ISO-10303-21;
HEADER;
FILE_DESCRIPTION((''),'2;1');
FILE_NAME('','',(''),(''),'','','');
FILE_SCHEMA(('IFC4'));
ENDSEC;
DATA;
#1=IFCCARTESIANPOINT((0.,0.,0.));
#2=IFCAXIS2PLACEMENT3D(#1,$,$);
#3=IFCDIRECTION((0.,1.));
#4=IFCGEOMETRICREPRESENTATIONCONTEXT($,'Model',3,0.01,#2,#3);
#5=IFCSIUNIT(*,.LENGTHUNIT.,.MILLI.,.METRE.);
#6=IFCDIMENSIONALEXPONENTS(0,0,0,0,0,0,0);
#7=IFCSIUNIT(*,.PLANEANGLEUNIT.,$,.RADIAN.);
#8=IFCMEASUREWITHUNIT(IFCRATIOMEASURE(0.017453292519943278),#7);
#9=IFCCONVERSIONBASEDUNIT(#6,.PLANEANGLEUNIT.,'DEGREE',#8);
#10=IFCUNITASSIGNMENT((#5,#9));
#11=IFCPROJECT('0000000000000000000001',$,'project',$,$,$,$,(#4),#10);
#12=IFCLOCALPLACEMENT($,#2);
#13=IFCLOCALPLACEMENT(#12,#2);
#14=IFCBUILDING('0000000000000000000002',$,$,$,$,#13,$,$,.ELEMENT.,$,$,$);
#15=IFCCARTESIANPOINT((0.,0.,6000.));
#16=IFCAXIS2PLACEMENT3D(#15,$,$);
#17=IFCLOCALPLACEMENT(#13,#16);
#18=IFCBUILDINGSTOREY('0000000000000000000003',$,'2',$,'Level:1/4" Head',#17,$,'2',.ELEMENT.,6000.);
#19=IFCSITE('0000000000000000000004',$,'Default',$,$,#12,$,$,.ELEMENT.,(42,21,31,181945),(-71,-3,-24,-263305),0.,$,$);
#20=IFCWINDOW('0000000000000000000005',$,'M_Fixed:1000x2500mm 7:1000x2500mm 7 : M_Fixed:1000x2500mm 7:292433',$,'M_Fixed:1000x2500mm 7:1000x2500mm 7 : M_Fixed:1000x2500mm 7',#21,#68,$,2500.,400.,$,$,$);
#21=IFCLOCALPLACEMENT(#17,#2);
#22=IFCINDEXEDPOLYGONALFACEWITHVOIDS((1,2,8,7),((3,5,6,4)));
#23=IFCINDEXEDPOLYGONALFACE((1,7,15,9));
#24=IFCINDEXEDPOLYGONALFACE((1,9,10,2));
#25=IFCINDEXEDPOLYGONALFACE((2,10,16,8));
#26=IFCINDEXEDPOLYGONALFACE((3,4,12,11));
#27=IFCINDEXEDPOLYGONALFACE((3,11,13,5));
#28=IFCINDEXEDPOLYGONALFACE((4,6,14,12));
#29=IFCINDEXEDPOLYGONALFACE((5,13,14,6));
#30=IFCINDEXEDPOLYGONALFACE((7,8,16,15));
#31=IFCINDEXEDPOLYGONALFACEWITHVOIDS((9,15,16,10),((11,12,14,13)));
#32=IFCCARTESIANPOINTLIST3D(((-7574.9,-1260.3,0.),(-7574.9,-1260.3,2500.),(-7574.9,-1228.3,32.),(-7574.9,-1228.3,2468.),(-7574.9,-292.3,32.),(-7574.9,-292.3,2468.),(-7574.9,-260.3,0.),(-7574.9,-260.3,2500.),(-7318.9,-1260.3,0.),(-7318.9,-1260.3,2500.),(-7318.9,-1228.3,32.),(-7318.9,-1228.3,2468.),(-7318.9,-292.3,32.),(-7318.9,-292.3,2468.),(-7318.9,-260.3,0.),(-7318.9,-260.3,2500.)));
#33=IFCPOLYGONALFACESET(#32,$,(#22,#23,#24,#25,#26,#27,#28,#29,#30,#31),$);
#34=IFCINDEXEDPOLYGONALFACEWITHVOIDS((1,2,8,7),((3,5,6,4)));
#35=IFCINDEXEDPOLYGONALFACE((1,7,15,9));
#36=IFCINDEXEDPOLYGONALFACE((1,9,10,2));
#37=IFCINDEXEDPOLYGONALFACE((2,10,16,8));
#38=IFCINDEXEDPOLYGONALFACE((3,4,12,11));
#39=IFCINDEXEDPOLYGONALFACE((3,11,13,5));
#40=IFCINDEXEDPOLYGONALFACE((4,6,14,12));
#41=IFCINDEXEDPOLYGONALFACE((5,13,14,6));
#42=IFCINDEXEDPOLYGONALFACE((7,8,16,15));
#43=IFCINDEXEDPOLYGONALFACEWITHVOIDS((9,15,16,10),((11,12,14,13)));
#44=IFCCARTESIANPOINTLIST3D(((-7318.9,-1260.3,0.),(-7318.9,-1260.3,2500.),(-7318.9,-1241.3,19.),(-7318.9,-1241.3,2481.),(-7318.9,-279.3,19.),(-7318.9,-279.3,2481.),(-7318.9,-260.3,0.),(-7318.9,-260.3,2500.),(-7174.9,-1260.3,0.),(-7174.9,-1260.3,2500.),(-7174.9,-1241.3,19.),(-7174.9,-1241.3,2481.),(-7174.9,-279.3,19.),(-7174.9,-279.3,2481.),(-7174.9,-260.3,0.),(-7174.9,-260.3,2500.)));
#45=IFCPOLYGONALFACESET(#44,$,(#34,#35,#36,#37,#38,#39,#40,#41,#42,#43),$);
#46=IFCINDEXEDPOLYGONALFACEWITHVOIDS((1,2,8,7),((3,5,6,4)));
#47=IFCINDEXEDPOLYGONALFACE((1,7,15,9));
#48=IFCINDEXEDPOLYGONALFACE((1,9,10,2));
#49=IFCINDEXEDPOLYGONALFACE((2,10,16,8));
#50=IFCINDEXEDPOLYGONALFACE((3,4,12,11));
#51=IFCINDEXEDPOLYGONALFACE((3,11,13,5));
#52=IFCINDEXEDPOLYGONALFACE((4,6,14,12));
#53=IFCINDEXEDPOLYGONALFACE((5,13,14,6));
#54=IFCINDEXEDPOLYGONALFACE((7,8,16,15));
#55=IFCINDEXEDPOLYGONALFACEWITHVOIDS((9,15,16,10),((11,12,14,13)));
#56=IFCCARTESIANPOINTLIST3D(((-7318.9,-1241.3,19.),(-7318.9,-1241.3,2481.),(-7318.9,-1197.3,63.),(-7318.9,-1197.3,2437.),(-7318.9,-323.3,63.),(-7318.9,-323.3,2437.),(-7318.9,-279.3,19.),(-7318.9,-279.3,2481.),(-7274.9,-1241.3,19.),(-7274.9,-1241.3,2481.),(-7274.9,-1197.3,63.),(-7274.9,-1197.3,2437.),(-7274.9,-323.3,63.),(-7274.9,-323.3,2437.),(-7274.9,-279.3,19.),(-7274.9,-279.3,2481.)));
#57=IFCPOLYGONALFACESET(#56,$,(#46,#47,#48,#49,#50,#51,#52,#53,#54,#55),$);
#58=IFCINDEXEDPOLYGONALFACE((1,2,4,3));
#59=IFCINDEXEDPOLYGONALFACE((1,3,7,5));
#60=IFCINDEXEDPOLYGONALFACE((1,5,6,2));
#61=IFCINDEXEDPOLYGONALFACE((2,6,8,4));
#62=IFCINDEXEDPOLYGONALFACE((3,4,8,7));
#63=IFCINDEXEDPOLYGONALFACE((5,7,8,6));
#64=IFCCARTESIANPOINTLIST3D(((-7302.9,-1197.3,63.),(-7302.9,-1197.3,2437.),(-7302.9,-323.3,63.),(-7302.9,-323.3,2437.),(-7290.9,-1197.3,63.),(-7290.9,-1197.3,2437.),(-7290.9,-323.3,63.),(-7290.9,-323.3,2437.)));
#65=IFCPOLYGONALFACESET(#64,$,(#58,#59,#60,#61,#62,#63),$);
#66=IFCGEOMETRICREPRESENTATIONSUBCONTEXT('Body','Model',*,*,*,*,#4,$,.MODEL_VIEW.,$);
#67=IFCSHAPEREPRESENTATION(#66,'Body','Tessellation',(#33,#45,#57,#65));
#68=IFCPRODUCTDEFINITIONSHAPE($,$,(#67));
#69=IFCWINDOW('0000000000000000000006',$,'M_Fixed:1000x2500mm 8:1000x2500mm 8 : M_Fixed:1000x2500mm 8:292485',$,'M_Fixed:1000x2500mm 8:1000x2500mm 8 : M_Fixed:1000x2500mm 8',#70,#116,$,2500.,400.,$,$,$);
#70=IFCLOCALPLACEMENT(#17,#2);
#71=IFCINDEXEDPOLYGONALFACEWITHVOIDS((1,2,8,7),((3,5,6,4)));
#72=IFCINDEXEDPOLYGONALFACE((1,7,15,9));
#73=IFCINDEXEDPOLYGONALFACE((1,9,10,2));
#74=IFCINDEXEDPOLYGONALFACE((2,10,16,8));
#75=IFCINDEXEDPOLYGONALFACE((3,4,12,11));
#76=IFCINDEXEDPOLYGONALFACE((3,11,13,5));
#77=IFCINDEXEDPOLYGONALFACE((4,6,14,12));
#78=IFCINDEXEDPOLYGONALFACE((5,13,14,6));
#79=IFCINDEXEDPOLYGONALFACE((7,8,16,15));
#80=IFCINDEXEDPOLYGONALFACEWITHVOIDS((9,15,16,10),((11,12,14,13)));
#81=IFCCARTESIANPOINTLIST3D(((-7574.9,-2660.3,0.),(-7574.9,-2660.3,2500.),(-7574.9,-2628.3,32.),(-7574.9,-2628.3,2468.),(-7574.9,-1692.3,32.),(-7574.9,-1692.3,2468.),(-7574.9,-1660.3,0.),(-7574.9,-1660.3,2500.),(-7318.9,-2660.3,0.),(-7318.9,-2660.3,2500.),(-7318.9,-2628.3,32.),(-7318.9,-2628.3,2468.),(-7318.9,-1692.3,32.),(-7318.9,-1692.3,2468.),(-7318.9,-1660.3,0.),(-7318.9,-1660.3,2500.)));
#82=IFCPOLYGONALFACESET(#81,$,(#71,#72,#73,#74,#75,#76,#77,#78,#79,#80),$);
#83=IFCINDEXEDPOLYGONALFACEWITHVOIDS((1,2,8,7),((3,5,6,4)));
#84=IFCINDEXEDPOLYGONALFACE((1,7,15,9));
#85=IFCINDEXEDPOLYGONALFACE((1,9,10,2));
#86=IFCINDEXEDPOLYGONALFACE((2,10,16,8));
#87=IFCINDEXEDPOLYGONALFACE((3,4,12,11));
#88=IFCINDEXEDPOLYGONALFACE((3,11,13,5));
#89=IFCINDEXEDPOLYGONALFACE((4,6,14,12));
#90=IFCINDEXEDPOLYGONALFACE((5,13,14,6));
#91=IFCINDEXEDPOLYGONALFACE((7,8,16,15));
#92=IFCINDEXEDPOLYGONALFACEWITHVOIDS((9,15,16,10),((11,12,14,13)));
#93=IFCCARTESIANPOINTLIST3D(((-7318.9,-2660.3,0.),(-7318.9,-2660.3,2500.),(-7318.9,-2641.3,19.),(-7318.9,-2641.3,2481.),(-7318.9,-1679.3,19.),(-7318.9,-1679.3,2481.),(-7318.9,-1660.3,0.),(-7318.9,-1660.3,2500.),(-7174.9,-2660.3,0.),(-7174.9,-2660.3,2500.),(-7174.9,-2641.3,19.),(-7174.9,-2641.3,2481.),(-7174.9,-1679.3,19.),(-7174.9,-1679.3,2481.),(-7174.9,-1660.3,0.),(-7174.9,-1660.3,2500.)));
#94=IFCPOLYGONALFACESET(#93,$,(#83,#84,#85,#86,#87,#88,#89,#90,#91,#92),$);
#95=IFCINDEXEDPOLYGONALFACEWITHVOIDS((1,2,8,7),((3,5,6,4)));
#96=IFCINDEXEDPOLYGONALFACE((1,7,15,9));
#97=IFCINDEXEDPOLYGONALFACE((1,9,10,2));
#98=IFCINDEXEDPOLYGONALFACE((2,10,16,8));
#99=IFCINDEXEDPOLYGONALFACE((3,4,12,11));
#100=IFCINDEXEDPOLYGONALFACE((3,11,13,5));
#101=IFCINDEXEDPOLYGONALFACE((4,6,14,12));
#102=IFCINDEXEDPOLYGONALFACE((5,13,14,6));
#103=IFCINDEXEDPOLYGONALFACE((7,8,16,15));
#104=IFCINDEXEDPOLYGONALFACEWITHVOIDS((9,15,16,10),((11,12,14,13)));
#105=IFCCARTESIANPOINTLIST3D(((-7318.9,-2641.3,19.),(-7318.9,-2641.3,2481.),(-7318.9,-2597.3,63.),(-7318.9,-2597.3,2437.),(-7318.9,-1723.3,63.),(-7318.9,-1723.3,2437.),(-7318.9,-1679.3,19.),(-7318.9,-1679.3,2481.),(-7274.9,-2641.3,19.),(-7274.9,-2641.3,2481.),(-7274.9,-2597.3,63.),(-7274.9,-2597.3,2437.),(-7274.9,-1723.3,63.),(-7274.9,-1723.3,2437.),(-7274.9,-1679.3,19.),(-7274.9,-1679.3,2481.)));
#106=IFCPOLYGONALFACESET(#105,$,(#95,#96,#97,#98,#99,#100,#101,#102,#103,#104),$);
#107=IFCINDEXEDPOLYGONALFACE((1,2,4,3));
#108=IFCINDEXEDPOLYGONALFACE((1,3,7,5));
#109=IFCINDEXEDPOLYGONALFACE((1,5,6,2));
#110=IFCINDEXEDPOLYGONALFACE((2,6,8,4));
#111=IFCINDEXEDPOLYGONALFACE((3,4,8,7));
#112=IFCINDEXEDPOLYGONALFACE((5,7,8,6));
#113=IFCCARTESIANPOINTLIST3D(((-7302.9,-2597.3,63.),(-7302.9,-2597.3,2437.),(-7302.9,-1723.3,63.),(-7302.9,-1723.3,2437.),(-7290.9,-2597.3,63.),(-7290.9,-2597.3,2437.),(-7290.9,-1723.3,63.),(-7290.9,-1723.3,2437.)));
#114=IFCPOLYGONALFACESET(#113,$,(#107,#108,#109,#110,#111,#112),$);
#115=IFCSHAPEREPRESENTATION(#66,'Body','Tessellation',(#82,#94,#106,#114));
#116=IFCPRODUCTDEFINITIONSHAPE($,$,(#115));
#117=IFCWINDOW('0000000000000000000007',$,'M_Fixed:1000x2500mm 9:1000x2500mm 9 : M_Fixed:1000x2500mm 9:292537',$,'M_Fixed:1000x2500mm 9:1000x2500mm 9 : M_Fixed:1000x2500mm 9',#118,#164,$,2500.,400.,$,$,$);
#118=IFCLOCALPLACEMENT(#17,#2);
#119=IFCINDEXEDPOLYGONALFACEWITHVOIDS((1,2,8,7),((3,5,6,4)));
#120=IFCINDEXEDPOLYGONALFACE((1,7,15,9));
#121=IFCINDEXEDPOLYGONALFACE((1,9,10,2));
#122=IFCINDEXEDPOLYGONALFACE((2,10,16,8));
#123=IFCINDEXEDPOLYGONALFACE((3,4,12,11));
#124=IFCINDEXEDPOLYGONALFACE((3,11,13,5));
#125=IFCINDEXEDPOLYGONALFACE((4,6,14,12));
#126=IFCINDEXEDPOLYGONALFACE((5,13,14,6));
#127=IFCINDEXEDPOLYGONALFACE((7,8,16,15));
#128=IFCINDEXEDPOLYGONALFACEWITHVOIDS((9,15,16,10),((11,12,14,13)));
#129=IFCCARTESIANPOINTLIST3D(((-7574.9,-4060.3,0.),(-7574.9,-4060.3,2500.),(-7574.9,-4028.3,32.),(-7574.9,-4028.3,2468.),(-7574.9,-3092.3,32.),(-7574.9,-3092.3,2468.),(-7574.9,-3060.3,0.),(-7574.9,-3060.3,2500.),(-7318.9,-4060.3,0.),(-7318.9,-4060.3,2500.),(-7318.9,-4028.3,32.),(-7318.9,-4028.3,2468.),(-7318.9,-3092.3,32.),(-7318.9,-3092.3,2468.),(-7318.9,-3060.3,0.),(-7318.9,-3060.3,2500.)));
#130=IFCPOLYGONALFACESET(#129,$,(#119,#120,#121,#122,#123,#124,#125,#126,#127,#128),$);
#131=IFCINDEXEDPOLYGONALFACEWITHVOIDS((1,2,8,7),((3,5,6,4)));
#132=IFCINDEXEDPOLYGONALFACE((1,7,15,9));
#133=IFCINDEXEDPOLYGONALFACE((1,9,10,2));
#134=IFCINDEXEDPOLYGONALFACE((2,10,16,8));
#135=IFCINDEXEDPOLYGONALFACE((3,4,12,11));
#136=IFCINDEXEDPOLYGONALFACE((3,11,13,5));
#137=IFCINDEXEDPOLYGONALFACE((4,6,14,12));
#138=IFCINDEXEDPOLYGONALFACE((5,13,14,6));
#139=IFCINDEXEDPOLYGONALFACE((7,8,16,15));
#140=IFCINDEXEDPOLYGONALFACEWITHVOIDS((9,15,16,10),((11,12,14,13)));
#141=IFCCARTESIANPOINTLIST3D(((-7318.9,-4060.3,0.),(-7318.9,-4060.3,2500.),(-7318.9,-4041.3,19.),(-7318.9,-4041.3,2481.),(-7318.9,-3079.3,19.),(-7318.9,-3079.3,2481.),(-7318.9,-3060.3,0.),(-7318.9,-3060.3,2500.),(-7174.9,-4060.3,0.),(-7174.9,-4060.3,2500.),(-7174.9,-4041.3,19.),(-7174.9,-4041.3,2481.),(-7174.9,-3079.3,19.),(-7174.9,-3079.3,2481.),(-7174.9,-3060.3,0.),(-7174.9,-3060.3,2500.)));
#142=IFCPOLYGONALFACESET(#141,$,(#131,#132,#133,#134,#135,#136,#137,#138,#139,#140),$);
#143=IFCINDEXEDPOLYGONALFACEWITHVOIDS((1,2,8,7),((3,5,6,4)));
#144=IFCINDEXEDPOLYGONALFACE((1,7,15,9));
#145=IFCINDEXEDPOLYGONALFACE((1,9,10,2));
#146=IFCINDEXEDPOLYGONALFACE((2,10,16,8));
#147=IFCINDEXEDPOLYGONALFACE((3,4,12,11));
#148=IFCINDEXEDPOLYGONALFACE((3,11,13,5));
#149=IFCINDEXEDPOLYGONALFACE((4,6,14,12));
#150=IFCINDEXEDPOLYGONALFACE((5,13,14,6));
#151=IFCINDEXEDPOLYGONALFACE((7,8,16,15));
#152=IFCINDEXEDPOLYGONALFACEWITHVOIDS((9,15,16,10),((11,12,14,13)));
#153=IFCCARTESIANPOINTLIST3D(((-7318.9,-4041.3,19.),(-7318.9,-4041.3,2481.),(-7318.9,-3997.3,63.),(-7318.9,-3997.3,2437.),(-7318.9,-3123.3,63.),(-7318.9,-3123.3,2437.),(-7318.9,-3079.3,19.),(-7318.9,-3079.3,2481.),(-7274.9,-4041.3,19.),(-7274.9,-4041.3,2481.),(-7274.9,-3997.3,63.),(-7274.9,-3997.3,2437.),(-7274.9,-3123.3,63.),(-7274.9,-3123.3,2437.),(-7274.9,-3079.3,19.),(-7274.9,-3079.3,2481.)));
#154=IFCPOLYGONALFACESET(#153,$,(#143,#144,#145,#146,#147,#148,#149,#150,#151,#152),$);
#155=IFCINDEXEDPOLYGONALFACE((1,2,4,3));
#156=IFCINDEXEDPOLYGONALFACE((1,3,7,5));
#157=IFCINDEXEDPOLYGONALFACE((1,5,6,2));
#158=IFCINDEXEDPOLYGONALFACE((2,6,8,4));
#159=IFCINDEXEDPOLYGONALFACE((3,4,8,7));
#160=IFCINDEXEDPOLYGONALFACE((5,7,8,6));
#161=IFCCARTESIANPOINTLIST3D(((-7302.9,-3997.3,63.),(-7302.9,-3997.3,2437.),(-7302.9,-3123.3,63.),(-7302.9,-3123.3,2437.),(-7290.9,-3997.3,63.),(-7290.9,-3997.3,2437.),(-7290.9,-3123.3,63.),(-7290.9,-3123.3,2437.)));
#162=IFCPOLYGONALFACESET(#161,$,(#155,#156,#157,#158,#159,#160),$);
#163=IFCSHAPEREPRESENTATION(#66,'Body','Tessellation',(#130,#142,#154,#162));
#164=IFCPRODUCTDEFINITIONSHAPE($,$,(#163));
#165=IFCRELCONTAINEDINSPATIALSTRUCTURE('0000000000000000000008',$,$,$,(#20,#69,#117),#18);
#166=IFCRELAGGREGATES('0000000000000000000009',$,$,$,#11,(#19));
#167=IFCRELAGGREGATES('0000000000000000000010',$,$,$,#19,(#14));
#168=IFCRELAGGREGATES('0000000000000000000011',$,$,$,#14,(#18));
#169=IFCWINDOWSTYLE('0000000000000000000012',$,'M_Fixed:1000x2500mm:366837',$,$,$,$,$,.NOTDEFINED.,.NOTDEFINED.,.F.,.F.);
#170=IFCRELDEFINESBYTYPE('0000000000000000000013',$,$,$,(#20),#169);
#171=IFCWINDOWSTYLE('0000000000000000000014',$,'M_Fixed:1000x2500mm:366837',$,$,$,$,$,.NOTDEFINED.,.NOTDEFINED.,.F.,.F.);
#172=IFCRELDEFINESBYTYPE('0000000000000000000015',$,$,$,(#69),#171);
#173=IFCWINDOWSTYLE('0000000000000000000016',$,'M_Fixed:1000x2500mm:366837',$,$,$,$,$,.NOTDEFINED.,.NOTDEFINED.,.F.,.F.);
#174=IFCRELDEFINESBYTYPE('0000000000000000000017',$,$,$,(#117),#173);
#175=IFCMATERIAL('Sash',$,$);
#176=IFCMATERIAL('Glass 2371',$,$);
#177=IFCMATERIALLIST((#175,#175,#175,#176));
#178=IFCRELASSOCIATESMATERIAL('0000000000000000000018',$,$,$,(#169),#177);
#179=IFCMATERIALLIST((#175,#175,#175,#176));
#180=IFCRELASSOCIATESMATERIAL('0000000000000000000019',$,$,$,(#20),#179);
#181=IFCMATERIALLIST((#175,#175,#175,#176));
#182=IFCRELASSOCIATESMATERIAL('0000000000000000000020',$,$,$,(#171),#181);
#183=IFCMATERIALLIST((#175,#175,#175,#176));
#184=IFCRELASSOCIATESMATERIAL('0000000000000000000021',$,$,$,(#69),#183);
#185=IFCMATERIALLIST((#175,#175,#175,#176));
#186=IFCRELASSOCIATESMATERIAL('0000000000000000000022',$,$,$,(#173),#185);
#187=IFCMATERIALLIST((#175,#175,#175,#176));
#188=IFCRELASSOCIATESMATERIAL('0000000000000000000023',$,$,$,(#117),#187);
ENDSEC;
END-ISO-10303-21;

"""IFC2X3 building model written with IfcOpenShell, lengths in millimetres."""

from ifc_helpers import new_model, entity, si_unit, converted_unit, direction, frame, frame_2d, origin, place, context, subcontext, project, spatial, polyline, rectangle, outline, extrude, source, transform, mapped, material, material_list, type_object, type_shapes, element, save


model = new_model("IFC2X3")

# Units and contexts
model_context = context("Model", 3, precision=0.01, world=origin(), true_north=direction((0.0, 1.0)))
body_context = subcontext(model_context, "Body", "Model", "MODEL_VIEW")
ifc_project = project(units=[si_unit("LENGTHUNIT", "METRE", prefix="MILLI"), converted_unit("PLANEANGLEUNIT", "DEGREE", entity("IfcRatioMeasure", 0.017453292519943278), si_unit("PLANEANGLEUNIT", "RADIAN"), dimensions=[0, 0, 0, 0, 0, 0, 0])], contexts=[model_context])

# Site, building, storey
site_placement = place(None, origin())
site = spatial("IfcSite", under=ifc_project, at=site_placement, Name="Default", CompositionType="ELEMENT", RefLatitude=(42, 21, 31, 181945), RefLongitude=(-71, -3, -24, -263305), RefElevation=0.0)
building_placement = place(site_placement, origin())
building = spatial("IfcBuilding", under=site, at=building_placement, CompositionType="ELEMENT")
storey_placement = place(building_placement, frame((0.0, 0.0, 6000.0)))
storey = spatial("IfcBuildingStorey", under=building, at=storey_placement, Name="2", ObjectType="Level:1/4\" Head", LongName="2", CompositionType="ELEMENT", Elevation=6000.0)

# Windows
ifc_material_1 = material(Name="Sash")
ifc_material_2 = material(Name="Glass 2371")
ifc_material_list_1 = material_list([ifc_material_1, ifc_material_1, ifc_material_1, ifc_material_2])
ifc_material_list_2 = material_list([ifc_material_1, ifc_material_1, ifc_material_1, ifc_material_2])
window_style_1 = type_object("IfcWindowStyle", Name="M_Fixed:1000x2500mm:366837", ConstructionType="NOTDEFINED", OperationType="NOTDEFINED", ParameterTakesPrecedence=False, Sizeable=False, material=ifc_material_list_2)
shared_shape_1 = source(origin(), body_context, "Body", "SweptSolid", [
    extrude(outline(polyline([(-1250.0, -500.0), (1250.0, -500.0), (1250.0, 500.0), (-1250.0, 500.0), (-1250.0, -500.0)]), holes=[polyline([(1218.0, 468.0), (1218.0, -468.0), (-1218.0, -468.0), (-1218.0, 468.0), (1218.0, 468.0)])]), frame((-7574.9, -760.3, 7250.0), z_axis=(1.0, 0.0, 0.0), x_axis=(0.0, 0.0, -1.0)), (0.0, 0.0, 1.0), 256.0),
    extrude(outline(polyline([(-1250.0, -500.0), (1250.0, -500.0), (1250.0, 500.0), (-1250.0, 500.0), (-1250.0, -500.0)]), holes=[polyline([(1231.0, 481.0), (1231.0, -481.0), (-1231.0, -481.0), (-1231.0, 481.0), (1231.0, 481.0)])]), frame((-7318.9, -760.3, 7250.0), z_axis=(1.0, 0.0, 0.0), x_axis=(0.0, 0.0, -1.0)), (0.0, 0.0, 1.0), 144.0),
    extrude(outline(polyline([(-1231.0, -481.0), (1231.0, -481.0), (1231.0, 481.0), (-1231.0, 481.0), (-1231.0, -481.0)]), holes=[polyline([(1187.0, 437.0), (1187.0, -437.0), (-1187.0, -437.0), (-1187.0, 437.0), (1187.0, 437.0)])]), frame((-7318.9, -760.3, 7250.0), z_axis=(1.0, 0.0, 0.0), x_axis=(0.0, 0.0, -1.0)), (0.0, 0.0, 1.0), 44.0),
    extrude(rectangle(XDim=874.0, YDim=12.0, at=frame_2d((0.0, 0.0), x_axis=(1.0, 0.0))), frame((-7296.9, -760.3, 6063.0), z_axis=(0.0, 0.0, 1.0), x_axis=(0.0, -1.0, 0.0)), (0.0, 0.0, 1.0), 2374.0),
])
type_shapes(window_style_1, [shared_shape_1])
window_1_placement = place(storey_placement, frame((0.0, 0.0, -6000.0)))
element("IfcWindow", 1, at=window_1_placement, inside=storey, type_object=window_style_1, material=ifc_material_list_1, Name="M_Fixed:1000x2500mm 7:1000x2500mm 7 : M_Fixed:1000x2500mm 7:292433", ObjectType="M_Fixed:1000x2500mm 7:1000x2500mm 7 : M_Fixed:1000x2500mm 7", OverallHeight=2500.0, OverallWidth=400.0, context=body_context, shape_type="MappedRepresentation", body=[
    mapped(shared_shape_1, transform((0.0, 0.0, 0.0), scale=1.0)),
])
ifc_material_list_3 = material_list([ifc_material_1, ifc_material_1, ifc_material_1, ifc_material_2])
ifc_material_list_4 = material_list([ifc_material_1, ifc_material_1, ifc_material_1, ifc_material_2])
window_style_2 = type_object("IfcWindowStyle", Name="M_Fixed:1000x2500mm:366837", ConstructionType="NOTDEFINED", OperationType="NOTDEFINED", ParameterTakesPrecedence=False, Sizeable=False, material=ifc_material_list_4)
shared_shape_2 = source(origin(), body_context, "Body", "SweptSolid", [
    extrude(outline(polyline([(-1250.0, -500.0), (1250.0, -500.0), (1250.0, 500.0), (-1250.0, 500.0), (-1250.0, -500.0)]), holes=[polyline([(1218.0, 468.0), (1218.0, -468.0), (-1218.0, -468.0), (-1218.0, 468.0), (1218.0, 468.0)])]), frame((-7574.9, -2160.3, 7250.0), z_axis=(1.0, 0.0, 0.0), x_axis=(0.0, 0.0, -1.0)), (0.0, 0.0, 1.0), 256.0),
    extrude(outline(polyline([(-1250.0, -500.0), (1250.0, -500.0), (1250.0, 500.0), (-1250.0, 500.0), (-1250.0, -500.0)]), holes=[polyline([(1231.0, 481.0), (1231.0, -481.0), (-1231.0, -481.0), (-1231.0, 481.0), (1231.0, 481.0)])]), frame((-7318.9, -2160.3, 7250.0), z_axis=(1.0, 0.0, 0.0), x_axis=(0.0, 0.0, -1.0)), (0.0, 0.0, 1.0), 144.0),
    extrude(outline(polyline([(-1231.0, -481.0), (1231.0, -481.0), (1231.0, 481.0), (-1231.0, 481.0), (-1231.0, -481.0)]), holes=[polyline([(1187.0, 437.0), (1187.0, -437.0), (-1187.0, -437.0), (-1187.0, 437.0), (1187.0, 437.0)])]), frame((-7318.9, -2160.3, 7250.0), z_axis=(1.0, 0.0, 0.0), x_axis=(0.0, 0.0, -1.0)), (0.0, 0.0, 1.0), 44.0),
    extrude(rectangle(XDim=874.0, YDim=12.0, at=frame_2d((0.0, 0.0), x_axis=(1.0, 0.0))), frame((-7296.9, -2160.3, 6063.0), z_axis=(0.0, 0.0, 1.0), x_axis=(0.0, -1.0, 0.0)), (0.0, 0.0, 1.0), 2374.0),
])
type_shapes(window_style_2, [shared_shape_2])
window_2_placement = place(storey_placement, frame((0.0, 0.0, -6000.0)))
element("IfcWindow", 2, at=window_2_placement, inside=storey, type_object=window_style_2, material=ifc_material_list_3, Name="M_Fixed:1000x2500mm 8:1000x2500mm 8 : M_Fixed:1000x2500mm 8:292485", ObjectType="M_Fixed:1000x2500mm 8:1000x2500mm 8 : M_Fixed:1000x2500mm 8", OverallHeight=2500.0, OverallWidth=400.0, context=body_context, shape_type="MappedRepresentation", body=[
    mapped(shared_shape_2, transform((0.0, 0.0, 0.0), scale=1.0)),
])
ifc_material_list_5 = material_list([ifc_material_1, ifc_material_1, ifc_material_1, ifc_material_2])
ifc_material_list_6 = material_list([ifc_material_1, ifc_material_1, ifc_material_1, ifc_material_2])
window_style_3 = type_object("IfcWindowStyle", Name="M_Fixed:1000x2500mm:366837", ConstructionType="NOTDEFINED", OperationType="NOTDEFINED", ParameterTakesPrecedence=False, Sizeable=False, material=ifc_material_list_6)
shared_shape_3 = source(origin(), body_context, "Body", "SweptSolid", [
    extrude(outline(polyline([(-1250.0, -500.0), (1250.0, -500.0), (1250.0, 500.0), (-1250.0, 500.0), (-1250.0, -500.0)]), holes=[polyline([(1218.0, 468.0), (1218.0, -468.0), (-1218.0, -468.0), (-1218.0, 468.0), (1218.0, 468.0)])]), frame((-7574.9, -3560.3, 7250.0), z_axis=(1.0, 0.0, 0.0), x_axis=(0.0, 0.0, -1.0)), (0.0, 0.0, 1.0), 256.0),
    extrude(outline(polyline([(-1250.0, -500.0), (1250.0, -500.0), (1250.0, 500.0), (-1250.0, 500.0), (-1250.0, -500.0)]), holes=[polyline([(1231.0, 481.0), (1231.0, -481.0), (-1231.0, -481.0), (-1231.0, 481.0), (1231.0, 481.0)])]), frame((-7318.9, -3560.3, 7250.0), z_axis=(1.0, 0.0, 0.0), x_axis=(0.0, 0.0, -1.0)), (0.0, 0.0, 1.0), 144.0),
    extrude(outline(polyline([(-1231.0, -481.0), (1231.0, -481.0), (1231.0, 481.0), (-1231.0, 481.0), (-1231.0, -481.0)]), holes=[polyline([(1187.0, 437.0), (1187.0, -437.0), (-1187.0, -437.0), (-1187.0, 437.0), (1187.0, 437.0)])]), frame((-7318.9, -3560.3, 7250.0), z_axis=(1.0, 0.0, 0.0), x_axis=(0.0, 0.0, -1.0)), (0.0, 0.0, 1.0), 44.0),
    extrude(rectangle(XDim=874.0, YDim=12.0, at=frame_2d((0.0, 0.0), x_axis=(1.0, 0.0))), frame((-7296.9, -3560.3, 6063.0), z_axis=(0.0, 0.0, 1.0), x_axis=(0.0, -1.0, 0.0)), (0.0, 0.0, 1.0), 2374.0),
])
type_shapes(window_style_3, [shared_shape_3])
window_3_placement = place(storey_placement, frame((0.0, 0.0, -6000.0)))
element("IfcWindow", 3, at=window_3_placement, inside=storey, type_object=window_style_3, material=ifc_material_list_5, Name="M_Fixed:1000x2500mm 9:1000x2500mm 9 : M_Fixed:1000x2500mm 9:292537", ObjectType="M_Fixed:1000x2500mm 9:1000x2500mm 9 : M_Fixed:1000x2500mm 9", OverallHeight=2500.0, OverallWidth=400.0, context=body_context, shape_type="MappedRepresentation", body=[
    mapped(shared_shape_3, transform((0.0, 0.0, 0.0), scale=1.0)),
])

save(model, "model.ifc")
